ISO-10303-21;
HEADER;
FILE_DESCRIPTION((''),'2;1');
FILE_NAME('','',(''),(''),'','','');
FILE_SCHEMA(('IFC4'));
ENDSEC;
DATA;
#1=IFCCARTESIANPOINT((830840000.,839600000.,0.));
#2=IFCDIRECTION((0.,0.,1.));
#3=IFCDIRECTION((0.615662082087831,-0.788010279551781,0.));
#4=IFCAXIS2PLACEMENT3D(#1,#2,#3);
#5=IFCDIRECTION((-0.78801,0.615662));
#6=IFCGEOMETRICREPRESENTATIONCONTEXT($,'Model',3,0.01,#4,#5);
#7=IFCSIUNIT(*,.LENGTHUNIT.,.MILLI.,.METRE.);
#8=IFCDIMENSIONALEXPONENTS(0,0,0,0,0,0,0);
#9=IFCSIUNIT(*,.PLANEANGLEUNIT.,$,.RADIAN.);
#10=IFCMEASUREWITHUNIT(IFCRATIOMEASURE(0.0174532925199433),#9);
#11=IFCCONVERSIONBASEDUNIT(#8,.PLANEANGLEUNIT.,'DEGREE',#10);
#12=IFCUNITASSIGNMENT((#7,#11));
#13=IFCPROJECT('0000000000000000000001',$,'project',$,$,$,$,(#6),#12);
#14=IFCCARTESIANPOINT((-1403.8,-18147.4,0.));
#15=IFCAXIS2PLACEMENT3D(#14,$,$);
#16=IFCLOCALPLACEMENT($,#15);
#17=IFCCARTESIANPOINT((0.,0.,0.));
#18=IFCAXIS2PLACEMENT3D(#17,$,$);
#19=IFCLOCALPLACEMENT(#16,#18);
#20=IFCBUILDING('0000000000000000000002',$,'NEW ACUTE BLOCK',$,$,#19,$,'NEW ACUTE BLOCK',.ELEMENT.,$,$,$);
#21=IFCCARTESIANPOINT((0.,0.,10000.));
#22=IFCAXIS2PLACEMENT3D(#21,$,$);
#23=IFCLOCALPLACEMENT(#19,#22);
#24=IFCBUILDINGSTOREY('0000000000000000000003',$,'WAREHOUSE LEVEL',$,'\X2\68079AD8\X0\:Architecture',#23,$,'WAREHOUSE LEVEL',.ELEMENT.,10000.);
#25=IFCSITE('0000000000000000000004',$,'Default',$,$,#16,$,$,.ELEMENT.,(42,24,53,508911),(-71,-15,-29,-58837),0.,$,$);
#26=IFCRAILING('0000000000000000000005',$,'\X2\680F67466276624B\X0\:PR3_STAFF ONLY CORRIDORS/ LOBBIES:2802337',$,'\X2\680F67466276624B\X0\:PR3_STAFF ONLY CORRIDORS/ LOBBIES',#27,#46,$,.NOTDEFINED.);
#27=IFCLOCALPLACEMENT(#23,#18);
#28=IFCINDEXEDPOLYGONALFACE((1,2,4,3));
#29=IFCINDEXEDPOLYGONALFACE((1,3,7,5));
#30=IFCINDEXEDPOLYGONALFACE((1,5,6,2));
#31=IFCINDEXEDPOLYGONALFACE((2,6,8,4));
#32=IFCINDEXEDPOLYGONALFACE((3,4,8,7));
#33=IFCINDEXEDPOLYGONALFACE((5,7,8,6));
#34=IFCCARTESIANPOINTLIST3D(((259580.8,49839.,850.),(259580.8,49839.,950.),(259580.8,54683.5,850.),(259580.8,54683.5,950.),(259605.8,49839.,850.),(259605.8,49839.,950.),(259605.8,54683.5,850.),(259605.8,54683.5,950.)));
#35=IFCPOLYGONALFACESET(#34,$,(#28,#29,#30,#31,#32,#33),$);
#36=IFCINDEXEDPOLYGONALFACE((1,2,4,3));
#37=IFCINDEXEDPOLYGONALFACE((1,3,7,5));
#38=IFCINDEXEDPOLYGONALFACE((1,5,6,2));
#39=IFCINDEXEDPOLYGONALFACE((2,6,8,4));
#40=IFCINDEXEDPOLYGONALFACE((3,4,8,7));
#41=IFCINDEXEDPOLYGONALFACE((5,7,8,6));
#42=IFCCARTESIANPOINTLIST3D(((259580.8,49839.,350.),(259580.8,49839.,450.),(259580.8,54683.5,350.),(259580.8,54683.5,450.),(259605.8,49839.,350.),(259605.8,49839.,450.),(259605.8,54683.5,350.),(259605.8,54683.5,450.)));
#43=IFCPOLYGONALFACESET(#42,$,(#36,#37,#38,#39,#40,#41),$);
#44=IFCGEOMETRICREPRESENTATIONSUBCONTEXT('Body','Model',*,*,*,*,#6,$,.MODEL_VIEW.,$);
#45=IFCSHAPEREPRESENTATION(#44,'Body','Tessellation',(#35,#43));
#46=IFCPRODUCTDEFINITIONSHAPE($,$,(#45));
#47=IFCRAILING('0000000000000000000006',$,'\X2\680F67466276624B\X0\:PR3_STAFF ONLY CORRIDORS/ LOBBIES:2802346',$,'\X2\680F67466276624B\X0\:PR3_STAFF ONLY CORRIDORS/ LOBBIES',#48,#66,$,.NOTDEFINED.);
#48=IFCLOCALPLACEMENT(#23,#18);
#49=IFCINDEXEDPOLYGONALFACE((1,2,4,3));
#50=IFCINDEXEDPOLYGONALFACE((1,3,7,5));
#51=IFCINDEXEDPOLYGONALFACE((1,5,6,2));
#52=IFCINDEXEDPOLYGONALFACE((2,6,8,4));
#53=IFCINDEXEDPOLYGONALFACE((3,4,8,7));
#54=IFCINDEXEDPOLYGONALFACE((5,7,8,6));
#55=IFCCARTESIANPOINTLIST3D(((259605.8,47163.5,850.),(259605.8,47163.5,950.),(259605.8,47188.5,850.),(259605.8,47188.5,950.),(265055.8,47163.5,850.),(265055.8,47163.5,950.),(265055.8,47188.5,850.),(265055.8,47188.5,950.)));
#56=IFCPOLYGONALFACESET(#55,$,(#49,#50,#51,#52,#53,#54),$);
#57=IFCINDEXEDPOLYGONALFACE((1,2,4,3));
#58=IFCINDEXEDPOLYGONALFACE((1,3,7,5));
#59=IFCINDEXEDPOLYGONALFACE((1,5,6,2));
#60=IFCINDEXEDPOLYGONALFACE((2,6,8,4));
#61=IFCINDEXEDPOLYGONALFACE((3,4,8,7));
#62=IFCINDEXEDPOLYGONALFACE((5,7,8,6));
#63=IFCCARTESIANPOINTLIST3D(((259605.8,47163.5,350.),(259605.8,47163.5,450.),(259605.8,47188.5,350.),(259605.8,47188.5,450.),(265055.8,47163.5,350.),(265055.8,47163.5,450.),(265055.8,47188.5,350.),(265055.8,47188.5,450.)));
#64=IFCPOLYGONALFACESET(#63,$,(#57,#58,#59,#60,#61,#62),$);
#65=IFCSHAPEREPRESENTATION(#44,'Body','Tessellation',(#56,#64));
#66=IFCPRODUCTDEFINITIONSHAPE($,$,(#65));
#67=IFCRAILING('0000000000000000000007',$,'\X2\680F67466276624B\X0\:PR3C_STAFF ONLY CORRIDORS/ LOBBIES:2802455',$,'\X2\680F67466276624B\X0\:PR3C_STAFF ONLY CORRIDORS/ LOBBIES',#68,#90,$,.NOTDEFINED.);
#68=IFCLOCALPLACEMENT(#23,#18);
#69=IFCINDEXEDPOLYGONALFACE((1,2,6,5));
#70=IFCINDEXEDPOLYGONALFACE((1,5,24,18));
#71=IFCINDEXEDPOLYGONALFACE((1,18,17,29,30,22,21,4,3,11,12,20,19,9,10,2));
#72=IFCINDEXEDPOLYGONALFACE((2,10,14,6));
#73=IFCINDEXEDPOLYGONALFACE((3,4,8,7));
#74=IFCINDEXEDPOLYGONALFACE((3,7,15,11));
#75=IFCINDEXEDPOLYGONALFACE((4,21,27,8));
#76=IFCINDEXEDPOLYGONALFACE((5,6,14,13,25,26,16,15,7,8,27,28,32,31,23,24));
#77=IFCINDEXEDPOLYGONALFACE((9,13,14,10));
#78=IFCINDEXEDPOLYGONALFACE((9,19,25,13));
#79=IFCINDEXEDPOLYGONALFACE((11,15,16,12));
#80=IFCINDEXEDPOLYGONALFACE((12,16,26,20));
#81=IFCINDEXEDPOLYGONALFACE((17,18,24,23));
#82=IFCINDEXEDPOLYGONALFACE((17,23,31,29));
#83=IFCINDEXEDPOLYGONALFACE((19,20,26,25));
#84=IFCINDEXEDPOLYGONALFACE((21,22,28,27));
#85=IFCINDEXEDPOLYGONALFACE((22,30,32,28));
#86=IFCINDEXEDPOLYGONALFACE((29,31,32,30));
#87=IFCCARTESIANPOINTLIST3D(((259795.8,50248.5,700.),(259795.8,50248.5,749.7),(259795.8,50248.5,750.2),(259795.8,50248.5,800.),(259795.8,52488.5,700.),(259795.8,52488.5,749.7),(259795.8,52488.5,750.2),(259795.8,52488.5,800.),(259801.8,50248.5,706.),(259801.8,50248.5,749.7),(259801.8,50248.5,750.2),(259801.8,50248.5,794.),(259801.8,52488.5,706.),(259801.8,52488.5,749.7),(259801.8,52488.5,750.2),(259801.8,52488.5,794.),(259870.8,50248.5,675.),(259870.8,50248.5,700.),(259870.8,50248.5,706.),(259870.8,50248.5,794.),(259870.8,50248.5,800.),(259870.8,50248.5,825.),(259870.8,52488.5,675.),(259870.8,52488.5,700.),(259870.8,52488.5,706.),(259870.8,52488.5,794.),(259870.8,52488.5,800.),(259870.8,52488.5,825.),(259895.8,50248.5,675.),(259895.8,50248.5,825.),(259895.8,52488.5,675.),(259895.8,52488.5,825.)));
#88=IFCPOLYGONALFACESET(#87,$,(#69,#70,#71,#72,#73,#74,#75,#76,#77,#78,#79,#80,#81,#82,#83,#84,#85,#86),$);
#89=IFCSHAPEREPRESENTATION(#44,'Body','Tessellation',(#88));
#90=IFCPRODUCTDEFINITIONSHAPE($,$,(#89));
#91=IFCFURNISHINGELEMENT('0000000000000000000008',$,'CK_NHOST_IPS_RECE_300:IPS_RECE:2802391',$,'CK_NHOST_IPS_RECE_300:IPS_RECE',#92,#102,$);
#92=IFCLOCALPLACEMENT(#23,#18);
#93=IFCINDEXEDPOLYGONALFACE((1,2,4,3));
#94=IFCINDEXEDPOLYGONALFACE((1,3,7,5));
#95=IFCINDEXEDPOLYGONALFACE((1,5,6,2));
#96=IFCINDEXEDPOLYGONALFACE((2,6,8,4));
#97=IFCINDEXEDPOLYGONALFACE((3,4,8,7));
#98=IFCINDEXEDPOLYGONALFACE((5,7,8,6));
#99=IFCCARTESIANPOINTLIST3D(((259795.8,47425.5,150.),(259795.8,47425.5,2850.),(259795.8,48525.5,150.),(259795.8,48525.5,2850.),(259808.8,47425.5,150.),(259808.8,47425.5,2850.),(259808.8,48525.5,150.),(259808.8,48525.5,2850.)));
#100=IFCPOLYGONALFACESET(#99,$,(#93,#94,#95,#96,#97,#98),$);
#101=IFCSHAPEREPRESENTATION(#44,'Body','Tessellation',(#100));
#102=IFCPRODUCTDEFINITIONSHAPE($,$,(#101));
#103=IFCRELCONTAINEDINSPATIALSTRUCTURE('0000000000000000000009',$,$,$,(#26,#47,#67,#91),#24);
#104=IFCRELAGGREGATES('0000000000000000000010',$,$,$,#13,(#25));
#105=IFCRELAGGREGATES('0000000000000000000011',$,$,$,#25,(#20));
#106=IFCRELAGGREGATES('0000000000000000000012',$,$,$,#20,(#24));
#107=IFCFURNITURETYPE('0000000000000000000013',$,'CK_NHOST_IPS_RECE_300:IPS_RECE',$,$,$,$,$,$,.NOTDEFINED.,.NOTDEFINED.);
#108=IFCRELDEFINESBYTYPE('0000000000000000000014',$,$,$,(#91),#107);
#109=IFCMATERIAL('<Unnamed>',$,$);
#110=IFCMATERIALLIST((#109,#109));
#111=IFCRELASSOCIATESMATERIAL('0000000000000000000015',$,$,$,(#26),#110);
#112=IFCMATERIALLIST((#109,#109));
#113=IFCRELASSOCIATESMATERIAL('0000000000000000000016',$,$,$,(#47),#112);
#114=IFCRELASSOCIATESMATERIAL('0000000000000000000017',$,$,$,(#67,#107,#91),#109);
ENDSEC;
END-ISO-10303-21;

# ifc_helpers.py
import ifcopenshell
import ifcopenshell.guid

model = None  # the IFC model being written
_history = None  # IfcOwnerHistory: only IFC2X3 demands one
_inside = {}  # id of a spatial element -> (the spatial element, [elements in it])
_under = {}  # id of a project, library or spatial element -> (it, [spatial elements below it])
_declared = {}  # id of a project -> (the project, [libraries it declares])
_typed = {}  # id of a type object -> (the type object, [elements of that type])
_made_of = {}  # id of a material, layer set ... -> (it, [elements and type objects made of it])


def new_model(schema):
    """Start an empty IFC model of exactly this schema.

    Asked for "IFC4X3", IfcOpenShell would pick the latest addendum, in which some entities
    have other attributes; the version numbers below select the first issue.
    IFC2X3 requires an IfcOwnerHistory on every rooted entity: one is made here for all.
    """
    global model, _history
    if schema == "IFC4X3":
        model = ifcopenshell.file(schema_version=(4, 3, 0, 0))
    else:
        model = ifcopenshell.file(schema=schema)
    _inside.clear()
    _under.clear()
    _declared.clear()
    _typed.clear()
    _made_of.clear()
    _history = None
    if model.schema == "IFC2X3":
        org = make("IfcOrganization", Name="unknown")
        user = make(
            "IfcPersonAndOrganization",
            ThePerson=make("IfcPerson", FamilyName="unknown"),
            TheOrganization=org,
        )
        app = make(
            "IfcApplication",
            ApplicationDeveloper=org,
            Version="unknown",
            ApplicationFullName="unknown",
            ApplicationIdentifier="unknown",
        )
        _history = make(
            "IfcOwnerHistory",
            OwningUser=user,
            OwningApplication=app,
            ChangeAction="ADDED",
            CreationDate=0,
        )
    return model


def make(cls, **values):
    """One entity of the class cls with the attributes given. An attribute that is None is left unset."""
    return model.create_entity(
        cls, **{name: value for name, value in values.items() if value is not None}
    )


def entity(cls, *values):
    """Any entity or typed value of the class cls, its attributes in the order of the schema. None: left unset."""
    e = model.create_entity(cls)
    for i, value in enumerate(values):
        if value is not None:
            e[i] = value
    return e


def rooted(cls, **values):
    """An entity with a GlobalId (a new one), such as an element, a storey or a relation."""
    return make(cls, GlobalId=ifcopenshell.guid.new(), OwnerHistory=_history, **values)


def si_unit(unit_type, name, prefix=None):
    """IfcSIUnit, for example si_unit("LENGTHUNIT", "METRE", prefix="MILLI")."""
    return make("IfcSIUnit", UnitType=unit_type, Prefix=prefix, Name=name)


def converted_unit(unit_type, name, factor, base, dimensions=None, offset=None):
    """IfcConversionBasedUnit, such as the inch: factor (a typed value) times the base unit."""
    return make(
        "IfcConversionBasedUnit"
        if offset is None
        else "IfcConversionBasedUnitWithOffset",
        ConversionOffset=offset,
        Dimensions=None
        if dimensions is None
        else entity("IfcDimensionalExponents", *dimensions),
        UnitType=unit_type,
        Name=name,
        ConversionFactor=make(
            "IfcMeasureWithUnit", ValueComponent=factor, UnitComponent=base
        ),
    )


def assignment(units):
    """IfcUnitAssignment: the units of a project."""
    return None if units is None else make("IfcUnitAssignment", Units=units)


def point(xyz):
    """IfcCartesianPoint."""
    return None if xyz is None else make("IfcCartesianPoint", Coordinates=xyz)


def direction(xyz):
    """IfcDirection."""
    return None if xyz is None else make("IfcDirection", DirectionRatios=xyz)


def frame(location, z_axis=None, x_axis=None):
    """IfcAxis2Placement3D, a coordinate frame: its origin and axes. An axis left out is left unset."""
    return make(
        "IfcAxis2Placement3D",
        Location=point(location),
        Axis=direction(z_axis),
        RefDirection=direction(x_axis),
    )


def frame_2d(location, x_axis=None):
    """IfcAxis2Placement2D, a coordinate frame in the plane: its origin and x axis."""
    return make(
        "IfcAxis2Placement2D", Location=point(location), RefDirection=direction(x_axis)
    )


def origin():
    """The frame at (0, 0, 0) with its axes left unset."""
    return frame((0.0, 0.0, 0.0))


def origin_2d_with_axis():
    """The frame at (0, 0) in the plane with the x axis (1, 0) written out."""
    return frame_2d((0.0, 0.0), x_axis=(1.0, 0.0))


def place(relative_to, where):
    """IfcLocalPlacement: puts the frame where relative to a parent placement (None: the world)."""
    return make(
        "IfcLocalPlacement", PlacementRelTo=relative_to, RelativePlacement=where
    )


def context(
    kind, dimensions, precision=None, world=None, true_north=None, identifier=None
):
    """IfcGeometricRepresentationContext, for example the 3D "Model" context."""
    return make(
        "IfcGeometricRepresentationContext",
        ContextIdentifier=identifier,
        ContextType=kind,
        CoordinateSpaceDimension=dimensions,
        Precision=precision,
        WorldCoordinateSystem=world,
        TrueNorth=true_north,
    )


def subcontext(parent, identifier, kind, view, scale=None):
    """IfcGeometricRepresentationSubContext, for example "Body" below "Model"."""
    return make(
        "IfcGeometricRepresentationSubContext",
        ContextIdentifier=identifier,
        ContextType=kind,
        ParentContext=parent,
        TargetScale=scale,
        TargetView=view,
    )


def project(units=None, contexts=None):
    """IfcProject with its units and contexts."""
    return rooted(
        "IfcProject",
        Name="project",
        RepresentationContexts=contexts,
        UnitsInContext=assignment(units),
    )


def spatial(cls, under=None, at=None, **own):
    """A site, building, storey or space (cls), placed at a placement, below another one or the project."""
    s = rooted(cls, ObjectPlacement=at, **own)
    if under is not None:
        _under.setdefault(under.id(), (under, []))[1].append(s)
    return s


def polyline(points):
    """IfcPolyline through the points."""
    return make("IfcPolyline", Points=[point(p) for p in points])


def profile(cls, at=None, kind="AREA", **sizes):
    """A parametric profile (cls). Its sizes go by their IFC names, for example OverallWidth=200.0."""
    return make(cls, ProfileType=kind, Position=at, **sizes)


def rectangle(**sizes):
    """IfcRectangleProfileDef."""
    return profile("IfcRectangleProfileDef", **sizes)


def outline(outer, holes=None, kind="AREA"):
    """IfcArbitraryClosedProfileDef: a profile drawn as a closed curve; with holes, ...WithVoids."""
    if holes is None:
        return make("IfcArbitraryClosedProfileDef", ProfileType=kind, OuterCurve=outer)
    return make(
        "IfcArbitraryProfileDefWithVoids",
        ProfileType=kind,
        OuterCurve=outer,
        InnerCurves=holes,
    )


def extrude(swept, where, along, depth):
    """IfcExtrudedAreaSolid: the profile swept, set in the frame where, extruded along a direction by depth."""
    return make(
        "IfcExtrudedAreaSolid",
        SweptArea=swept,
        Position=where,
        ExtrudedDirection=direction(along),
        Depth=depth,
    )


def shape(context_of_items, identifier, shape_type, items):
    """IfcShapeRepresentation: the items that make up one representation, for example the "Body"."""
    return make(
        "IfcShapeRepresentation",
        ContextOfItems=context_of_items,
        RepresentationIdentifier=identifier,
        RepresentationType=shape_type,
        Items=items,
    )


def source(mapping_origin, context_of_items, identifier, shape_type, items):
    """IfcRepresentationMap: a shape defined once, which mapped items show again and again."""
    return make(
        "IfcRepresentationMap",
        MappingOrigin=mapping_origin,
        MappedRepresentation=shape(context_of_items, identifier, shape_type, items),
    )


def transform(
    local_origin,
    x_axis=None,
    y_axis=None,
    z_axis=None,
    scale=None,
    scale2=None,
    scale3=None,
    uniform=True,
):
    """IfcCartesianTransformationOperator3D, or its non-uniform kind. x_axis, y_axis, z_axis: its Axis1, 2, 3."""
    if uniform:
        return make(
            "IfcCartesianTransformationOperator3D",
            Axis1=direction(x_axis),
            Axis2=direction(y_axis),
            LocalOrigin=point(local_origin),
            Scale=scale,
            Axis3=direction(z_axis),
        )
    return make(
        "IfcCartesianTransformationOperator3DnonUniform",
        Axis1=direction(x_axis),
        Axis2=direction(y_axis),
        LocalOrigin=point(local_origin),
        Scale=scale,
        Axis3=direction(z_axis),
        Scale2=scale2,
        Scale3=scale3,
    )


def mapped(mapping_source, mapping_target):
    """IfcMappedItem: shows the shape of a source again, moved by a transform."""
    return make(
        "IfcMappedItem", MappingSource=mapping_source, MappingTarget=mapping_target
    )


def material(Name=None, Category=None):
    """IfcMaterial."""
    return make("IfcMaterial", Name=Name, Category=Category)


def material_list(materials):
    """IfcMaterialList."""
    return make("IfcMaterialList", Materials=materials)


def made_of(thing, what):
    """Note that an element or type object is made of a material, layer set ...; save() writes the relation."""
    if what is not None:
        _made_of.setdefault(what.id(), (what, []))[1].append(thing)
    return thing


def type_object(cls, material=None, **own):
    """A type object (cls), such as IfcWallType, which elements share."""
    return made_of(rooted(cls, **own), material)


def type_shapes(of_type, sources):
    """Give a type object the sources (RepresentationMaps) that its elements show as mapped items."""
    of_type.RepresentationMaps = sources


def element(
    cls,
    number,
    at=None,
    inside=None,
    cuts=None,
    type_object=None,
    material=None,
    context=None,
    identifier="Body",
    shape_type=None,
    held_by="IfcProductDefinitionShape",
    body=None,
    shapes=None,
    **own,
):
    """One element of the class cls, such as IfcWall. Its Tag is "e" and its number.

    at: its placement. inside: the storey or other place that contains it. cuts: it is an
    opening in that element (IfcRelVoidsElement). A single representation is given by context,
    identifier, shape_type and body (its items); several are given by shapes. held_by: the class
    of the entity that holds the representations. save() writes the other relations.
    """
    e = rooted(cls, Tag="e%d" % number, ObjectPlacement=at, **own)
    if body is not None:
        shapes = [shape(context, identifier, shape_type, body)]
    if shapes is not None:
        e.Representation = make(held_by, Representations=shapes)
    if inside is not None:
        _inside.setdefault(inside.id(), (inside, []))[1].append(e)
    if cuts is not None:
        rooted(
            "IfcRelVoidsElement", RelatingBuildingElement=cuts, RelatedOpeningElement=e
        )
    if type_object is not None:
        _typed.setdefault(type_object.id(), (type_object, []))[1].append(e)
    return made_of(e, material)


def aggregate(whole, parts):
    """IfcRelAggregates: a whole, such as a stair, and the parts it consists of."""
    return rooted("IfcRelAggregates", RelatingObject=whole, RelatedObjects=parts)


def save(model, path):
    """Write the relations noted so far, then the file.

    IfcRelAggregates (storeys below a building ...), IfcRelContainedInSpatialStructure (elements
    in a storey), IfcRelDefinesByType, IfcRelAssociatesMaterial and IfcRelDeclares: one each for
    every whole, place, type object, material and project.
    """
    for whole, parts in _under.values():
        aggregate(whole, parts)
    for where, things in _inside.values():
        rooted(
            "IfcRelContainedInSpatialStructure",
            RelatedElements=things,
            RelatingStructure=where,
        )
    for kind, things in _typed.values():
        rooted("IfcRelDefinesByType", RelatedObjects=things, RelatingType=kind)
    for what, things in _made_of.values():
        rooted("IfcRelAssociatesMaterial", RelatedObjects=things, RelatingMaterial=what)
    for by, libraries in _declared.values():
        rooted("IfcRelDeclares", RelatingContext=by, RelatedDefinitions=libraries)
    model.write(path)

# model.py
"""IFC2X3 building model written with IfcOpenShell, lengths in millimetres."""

from ifc_helpers import new_model, entity, si_unit, converted_unit, direction, frame, frame_2d, origin, origin_2d_with_axis, place, context, subcontext, project, spatial, polyline, rectangle, outline, extrude, source, transform, mapped, material, material_list, type_object, type_shapes, element, save


model = new_model("IFC2X3")

# Units and contexts
model_context = context("Model", 3, precision=0.01, world=frame((830840000.0, 839600000.0, 0.0), z_axis=(0.0, 0.0, 1.0), x_axis=(0.615662082087831, -0.788010279551781, 0.0)), true_north=direction((-0.78801, 0.615662)))
body_context = subcontext(model_context, "Body", "Model", "MODEL_VIEW")
ifc_project = project(units=[si_unit("LENGTHUNIT", "METRE", prefix="MILLI"), converted_unit("PLANEANGLEUNIT", "DEGREE", entity("IfcRatioMeasure", 0.0174532925199433), si_unit("PLANEANGLEUNIT", "RADIAN"), dimensions=[0, 0, 0, 0, 0, 0, 0])], contexts=[model_context])

# Site, building, storey
site_placement = place(None, frame((-1403.8, -18147.4, 0.0)))
site = spatial("IfcSite", under=ifc_project, at=site_placement, Name="Default", CompositionType="ELEMENT", RefLatitude=(42, 24, 53, 508911), RefLongitude=(-71, -15, -29, -58837), RefElevation=0.0)
building_placement = place(site_placement, origin())
building = spatial("IfcBuilding", under=site, at=building_placement, Name="NEW ACUTE BLOCK", LongName="NEW ACUTE BLOCK", CompositionType="ELEMENT")
storey_placement = place(building_placement, frame((0.0, 0.0, 10000.0)))
storey = spatial("IfcBuildingStorey", under=building, at=storey_placement, Name="WAREHOUSE LEVEL", ObjectType="标高:Architecture", LongName="WAREHOUSE LEVEL", CompositionType="ELEMENT", Elevation=10000.0)

# Shared definitions
ifc_material_1 = material(Name="<Unnamed>")

# Railings
ifc_material_list_1 = material_list([ifc_material_1, ifc_material_1])
railing_1_placement = place(storey_placement, frame((259580.8, 49839.0, 350.0)))
element("IfcRailing", 1, at=railing_1_placement, inside=storey, material=ifc_material_list_1, Name="栏杆扶手:PR3_STAFF ONLY CORRIDORS/ LOBBIES:2802337", ObjectType="栏杆扶手:PR3_STAFF ONLY CORRIDORS/ LOBBIES", PredefinedType="NOTDEFINED", context=body_context, shape_type="SweptSolid", body=[
    extrude(rectangle(XDim=4844.5, YDim=25.0, at=frame_2d((0.0, 0.0), x_axis=(1.0, 0.0))), frame((12.5, 2422.3, 500.0), z_axis=(0.0, 0.0, 1.0), x_axis=(0.0, -1.0, 0.0)), (0.0, 0.0, 1.0), 100.0),
    extrude(rectangle(XDim=4844.5, YDim=25.0, at=frame_2d((0.0, 0.0), x_axis=(1.0, 0.0))), frame((12.5, 2422.3, 0.0), z_axis=(0.0, 0.0, 1.0), x_axis=(0.0, -1.0, 0.0)), (0.0, 0.0, 1.0), 100.0),
])
ifc_material_list_2 = material_list([ifc_material_1, ifc_material_1])
railing_2_placement = place(storey_placement, frame((259605.8, 47163.5, 350.0)))
element("IfcRailing", 2, at=railing_2_placement, inside=storey, material=ifc_material_list_2, Name="栏杆扶手:PR3_STAFF ONLY CORRIDORS/ LOBBIES:2802346", ObjectType="栏杆扶手:PR3_STAFF ONLY CORRIDORS/ LOBBIES", PredefinedType="NOTDEFINED", context=body_context, shape_type="SweptSolid", body=[
    extrude(rectangle(XDim=5450.0, YDim=25.0, at=frame_2d((0.0, 0.0), x_axis=(1.0, 0.0))), frame((2725.0, 12.5, 500.0)), (0.0, 0.0, 1.0), 100.0),
    extrude(rectangle(XDim=5450.0, YDim=25.0, at=frame_2d((0.0, 0.0), x_axis=(1.0, 0.0))), frame((2725.0, 12.5, 0.0)), (0.0, 0.0, 1.0), 100.0),
])
railing_3_placement = place(storey_placement, frame((259795.8, 50248.5, 675.0)))
element("IfcRailing", 3, at=railing_3_placement, inside=storey, material=ifc_material_1, Name="栏杆扶手:PR3C_STAFF ONLY CORRIDORS/ LOBBIES:2802455", ObjectType="栏杆扶手:PR3C_STAFF ONLY CORRIDORS/ LOBBIES", PredefinedType="NOTDEFINED", context=body_context, shape_type="SweptSolid", body=[
    extrude(outline(polyline([(-75.0, -32.9), (-75.0, -57.9), (75.0, -57.9), (75.0, -32.9), (50.0, -32.9), (50.0, 42.1), (0.2, 42.1), (0.2, 36.1), (44.0, 36.1), (44.0, -32.9), (-44.0, -32.9), (-44.0, 36.1), (-0.3, 36.1), (-0.3, 42.1), (-50.0, 42.1), (-50.0, -32.9), (-75.0, -32.9)])), frame((42.1, 0.0, 75.0), z_axis=(0.0, -1.0, 0.0), x_axis=(0.0, 0.0, 1.0)), (0.0, 0.0, -1.0), 2240.0),
])

# Furnishing element
furniture_type_1 = type_object("IfcFurnitureType", Name="CK_NHOST_IPS_RECE_300:IPS_RECE", material=ifc_material_1)
shared_shape_1 = source(origin(), body_context, "Body", "SweptSolid", [
    extrude(rectangle(XDim=1100.0, YDim=13.0, at=origin_2d_with_axis()), frame((550.0, 6.5, 0.0), z_axis=(0.0, 0.0, 1.0), x_axis=(-1.0, 0.0, 0.0)), (0.0, 0.0, 1.0), 2700.0),
])
type_shapes(furniture_type_1, [shared_shape_1])
furnishing_1_placement = place(storey_placement, frame((259808.8, 47425.5, 150.0), z_axis=(0.0, 0.0, 1.0), x_axis=(0.0, 1.0, 0.0)))
element("IfcFurnishingElement", 4, at=furnishing_1_placement, inside=storey, type_object=furniture_type_1, material=ifc_material_1, Name="CK_NHOST_IPS_RECE_300:IPS_RECE:2802391", ObjectType="CK_NHOST_IPS_RECE_300:IPS_RECE", context=body_context, shape_type="MappedRepresentation", body=[
    mapped(shared_shape_1, transform((0.0, 0.0, 0.0), scale=1.0)),
])

save(model, "model.ifc")
